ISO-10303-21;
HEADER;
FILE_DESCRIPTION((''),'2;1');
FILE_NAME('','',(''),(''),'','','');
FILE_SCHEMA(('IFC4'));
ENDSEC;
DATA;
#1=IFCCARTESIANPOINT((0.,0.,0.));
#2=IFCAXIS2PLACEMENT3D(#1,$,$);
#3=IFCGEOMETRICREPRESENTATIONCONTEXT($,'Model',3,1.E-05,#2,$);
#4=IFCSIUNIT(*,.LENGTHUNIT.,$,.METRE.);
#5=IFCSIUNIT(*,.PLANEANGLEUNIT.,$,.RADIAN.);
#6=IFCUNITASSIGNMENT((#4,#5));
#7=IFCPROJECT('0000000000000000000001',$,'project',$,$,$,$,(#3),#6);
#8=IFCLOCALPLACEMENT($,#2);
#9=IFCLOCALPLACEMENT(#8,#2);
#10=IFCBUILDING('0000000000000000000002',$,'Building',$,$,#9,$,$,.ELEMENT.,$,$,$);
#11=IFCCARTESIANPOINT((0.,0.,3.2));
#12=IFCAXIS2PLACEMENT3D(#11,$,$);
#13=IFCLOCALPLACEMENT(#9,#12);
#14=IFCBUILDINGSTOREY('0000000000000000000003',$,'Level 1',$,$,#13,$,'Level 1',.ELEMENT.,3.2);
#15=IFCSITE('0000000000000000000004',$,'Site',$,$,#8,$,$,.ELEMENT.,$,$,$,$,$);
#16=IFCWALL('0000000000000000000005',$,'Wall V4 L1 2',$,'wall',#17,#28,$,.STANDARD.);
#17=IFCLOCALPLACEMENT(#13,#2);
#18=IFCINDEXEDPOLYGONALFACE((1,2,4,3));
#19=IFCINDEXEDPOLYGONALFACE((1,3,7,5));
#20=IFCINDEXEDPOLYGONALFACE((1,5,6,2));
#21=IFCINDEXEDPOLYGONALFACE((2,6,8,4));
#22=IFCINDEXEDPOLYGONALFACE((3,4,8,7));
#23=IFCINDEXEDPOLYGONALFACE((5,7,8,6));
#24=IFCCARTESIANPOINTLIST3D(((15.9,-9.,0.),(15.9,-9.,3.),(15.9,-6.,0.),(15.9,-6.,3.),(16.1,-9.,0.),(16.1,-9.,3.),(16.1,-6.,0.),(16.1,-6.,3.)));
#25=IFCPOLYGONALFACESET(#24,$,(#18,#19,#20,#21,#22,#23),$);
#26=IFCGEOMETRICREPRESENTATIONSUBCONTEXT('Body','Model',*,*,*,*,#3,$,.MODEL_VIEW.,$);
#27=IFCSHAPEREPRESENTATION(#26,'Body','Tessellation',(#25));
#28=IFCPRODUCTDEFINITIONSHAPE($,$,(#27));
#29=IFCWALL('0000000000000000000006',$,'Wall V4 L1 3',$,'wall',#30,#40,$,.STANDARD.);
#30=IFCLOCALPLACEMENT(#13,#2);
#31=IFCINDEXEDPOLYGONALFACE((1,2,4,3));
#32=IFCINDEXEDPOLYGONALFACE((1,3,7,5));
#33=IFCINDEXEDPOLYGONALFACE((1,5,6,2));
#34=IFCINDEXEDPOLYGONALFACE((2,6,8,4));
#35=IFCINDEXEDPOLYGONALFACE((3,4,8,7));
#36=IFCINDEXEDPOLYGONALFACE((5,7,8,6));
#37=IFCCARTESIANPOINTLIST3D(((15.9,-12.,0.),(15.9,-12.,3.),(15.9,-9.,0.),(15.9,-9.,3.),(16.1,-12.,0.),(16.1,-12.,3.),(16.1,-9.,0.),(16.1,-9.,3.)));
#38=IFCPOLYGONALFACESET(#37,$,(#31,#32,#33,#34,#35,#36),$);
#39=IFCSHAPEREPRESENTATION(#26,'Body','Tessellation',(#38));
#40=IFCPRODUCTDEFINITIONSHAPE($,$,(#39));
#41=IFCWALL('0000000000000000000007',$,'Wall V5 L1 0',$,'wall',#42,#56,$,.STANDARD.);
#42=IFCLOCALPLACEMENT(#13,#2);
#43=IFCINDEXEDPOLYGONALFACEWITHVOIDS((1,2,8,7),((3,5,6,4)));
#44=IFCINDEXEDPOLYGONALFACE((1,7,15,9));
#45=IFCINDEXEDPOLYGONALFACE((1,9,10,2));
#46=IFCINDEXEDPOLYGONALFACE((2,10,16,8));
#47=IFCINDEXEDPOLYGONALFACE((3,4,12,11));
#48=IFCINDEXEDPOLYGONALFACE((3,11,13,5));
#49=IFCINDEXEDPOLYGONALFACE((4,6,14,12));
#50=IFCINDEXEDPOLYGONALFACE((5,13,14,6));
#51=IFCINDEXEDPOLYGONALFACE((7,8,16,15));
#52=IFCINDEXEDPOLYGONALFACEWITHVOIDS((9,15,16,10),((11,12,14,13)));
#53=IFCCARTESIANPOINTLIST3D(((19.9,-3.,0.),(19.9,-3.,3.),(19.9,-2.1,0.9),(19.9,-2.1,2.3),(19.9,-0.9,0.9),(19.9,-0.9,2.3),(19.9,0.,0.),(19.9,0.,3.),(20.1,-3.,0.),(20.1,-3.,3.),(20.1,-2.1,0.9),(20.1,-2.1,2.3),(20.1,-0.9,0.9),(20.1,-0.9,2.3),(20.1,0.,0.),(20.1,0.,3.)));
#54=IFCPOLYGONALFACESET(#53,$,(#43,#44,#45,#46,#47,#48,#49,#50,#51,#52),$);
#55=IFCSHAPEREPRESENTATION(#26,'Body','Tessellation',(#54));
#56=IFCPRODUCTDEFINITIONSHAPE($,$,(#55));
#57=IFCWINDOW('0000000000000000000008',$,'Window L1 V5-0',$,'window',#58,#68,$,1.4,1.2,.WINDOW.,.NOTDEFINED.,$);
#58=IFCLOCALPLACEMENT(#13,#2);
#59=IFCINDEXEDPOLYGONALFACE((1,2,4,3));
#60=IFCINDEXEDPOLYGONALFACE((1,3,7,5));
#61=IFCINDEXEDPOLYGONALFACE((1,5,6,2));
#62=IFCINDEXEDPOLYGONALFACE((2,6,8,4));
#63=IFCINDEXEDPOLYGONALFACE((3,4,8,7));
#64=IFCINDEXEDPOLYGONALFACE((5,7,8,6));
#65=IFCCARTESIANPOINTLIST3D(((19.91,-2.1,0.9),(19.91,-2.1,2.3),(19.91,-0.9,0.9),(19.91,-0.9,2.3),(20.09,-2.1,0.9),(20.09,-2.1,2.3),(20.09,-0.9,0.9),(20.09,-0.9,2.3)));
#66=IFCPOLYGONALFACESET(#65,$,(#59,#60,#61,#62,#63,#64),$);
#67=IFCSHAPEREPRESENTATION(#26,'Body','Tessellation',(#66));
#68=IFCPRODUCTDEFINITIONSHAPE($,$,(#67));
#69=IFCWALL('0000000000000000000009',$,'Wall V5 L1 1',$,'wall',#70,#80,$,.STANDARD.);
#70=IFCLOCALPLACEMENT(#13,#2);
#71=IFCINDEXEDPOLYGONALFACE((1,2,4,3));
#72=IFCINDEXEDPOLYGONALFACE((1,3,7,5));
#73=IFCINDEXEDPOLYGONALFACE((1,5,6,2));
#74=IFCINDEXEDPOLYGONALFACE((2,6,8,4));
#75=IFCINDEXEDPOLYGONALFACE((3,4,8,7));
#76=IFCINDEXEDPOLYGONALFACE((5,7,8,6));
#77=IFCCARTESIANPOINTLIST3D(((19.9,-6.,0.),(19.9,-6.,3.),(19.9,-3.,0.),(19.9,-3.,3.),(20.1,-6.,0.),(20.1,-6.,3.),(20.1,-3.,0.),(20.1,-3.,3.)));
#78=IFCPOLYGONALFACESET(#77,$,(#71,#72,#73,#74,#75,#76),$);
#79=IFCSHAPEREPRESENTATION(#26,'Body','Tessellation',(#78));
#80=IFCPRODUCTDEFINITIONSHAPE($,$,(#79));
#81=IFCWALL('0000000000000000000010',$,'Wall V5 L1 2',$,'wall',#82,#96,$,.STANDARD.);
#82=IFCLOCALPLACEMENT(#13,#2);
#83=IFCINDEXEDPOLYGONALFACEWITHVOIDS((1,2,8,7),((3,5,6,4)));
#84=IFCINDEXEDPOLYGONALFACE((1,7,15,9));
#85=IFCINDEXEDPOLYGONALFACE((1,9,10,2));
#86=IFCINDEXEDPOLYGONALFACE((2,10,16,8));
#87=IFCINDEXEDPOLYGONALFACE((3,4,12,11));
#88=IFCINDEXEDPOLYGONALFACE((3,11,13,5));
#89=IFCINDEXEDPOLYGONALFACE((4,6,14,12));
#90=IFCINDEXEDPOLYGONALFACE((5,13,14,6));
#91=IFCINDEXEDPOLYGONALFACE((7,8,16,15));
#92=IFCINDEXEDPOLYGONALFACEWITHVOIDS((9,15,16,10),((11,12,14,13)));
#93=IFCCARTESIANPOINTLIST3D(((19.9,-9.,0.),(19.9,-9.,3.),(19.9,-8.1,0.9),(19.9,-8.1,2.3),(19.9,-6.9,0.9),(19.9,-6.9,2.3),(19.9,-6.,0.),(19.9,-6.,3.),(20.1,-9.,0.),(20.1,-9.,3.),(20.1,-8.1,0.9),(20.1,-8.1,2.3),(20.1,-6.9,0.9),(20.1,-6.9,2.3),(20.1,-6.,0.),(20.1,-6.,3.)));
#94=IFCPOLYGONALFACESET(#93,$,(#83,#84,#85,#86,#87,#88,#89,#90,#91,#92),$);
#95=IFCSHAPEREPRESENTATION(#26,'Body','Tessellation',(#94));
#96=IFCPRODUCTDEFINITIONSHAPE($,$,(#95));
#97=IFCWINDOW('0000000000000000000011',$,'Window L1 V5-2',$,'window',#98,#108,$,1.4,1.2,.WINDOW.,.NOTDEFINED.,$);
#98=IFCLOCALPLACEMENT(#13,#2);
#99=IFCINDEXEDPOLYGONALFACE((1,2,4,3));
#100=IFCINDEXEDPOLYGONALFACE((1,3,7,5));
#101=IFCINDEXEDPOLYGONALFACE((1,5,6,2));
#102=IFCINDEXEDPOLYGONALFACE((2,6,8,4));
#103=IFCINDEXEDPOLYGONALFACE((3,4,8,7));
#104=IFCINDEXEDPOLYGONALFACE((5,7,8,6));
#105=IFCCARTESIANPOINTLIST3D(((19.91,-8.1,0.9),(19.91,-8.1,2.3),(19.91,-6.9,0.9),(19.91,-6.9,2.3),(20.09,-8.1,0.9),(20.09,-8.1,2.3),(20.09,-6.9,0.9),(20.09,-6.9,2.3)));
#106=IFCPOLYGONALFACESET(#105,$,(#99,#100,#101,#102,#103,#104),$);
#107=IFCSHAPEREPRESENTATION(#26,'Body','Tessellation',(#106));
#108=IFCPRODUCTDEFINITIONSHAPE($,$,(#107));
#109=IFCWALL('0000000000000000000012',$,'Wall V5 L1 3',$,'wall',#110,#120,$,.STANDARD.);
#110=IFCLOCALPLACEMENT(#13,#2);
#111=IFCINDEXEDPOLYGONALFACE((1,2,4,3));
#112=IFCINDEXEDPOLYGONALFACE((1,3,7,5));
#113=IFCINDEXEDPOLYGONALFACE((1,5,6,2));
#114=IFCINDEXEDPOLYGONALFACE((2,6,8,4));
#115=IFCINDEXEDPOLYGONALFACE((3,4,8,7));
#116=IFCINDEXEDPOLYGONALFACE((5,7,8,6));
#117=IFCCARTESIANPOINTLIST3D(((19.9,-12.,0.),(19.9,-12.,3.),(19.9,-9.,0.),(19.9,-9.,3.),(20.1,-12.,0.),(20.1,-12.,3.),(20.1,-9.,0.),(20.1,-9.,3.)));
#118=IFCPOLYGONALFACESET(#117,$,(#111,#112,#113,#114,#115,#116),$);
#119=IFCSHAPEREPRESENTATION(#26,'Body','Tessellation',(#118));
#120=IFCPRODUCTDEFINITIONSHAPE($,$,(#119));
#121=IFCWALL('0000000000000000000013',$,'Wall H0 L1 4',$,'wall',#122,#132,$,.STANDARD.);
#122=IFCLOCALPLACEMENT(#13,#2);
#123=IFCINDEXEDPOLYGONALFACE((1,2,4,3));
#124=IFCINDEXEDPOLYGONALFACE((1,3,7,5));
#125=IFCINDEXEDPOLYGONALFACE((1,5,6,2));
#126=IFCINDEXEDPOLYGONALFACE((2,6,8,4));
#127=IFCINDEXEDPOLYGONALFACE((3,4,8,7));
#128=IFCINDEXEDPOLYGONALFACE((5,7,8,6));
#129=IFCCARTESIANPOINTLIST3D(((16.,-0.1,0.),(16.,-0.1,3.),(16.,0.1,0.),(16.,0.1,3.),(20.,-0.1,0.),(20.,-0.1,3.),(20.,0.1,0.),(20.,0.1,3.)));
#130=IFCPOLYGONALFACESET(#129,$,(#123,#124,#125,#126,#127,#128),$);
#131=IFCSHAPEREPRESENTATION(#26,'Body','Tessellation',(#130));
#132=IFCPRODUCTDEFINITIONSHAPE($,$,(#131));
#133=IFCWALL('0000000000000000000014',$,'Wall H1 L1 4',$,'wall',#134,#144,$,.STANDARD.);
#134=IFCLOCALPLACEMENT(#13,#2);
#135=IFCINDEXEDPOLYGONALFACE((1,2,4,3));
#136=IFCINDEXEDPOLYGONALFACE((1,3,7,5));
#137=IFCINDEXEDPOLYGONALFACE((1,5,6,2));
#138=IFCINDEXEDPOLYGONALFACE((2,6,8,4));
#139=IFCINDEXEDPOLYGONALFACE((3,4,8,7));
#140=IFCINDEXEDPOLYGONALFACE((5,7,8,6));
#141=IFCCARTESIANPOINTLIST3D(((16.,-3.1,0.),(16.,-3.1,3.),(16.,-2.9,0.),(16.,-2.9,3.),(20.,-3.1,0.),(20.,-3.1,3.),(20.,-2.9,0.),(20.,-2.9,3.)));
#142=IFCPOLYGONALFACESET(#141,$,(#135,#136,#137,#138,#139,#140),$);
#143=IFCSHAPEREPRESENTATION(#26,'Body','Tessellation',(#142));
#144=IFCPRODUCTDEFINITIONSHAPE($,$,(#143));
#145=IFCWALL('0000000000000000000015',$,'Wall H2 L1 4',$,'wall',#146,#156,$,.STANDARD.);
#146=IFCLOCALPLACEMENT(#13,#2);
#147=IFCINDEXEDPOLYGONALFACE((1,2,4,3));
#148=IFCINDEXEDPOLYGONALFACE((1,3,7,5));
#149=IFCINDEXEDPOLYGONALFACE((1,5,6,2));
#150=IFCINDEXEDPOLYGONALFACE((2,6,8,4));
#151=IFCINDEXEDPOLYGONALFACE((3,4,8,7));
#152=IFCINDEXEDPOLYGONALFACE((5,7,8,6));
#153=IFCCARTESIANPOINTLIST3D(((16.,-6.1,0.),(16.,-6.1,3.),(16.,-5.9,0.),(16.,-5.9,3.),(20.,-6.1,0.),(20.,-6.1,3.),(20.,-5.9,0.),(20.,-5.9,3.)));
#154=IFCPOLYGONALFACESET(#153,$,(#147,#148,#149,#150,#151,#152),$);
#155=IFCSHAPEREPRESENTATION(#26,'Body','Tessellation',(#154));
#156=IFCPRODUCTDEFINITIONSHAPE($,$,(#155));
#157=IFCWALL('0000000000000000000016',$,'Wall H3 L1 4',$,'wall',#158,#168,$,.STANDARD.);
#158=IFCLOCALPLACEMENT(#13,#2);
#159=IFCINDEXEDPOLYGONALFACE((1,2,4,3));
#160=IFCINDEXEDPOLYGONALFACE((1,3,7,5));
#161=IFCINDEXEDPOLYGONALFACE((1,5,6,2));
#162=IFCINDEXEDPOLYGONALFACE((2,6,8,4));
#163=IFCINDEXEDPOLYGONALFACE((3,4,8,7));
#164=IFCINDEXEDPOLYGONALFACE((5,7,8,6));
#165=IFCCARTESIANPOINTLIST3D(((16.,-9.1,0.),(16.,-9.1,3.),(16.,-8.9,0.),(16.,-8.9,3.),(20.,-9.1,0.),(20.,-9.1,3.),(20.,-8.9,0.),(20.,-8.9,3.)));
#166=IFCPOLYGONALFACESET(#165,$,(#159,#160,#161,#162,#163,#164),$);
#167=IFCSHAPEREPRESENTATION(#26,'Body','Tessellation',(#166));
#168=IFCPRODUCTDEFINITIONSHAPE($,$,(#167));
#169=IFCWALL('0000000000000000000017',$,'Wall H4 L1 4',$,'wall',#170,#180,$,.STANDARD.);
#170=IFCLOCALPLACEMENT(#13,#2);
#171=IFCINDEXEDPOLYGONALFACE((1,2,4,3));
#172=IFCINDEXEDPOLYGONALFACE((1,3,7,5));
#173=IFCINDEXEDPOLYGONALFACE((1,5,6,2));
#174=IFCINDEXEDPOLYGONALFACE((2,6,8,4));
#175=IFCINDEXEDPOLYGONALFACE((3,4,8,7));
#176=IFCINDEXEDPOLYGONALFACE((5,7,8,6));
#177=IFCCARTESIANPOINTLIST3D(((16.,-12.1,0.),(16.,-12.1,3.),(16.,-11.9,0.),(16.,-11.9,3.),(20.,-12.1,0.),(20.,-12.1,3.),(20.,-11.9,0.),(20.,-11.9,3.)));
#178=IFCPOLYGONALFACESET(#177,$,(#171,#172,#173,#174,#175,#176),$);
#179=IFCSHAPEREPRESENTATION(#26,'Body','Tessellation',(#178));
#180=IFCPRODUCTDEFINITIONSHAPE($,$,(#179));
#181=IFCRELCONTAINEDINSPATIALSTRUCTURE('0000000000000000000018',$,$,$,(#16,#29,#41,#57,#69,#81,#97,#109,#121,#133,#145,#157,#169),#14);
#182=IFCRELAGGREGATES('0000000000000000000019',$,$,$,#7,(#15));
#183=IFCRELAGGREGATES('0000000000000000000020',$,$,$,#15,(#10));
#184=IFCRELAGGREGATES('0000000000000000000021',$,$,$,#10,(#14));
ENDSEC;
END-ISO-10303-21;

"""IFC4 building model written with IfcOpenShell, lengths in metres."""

from ifc_helpers import new_model, si_unit, frame, frame_2d, origin, origin_2d, place, context, subcontext, project, spatial, rectangle, extrude, element, fill, save


model = new_model("IFC4")

# Units and contexts
model_context = context("Model", 3, precision=1e-05, world=origin())
body_context = subcontext(model_context, "Body", "Model", "MODEL_VIEW")
ifc_project = project(units=[si_unit("LENGTHUNIT", "METRE"), si_unit("PLANEANGLEUNIT", "RADIAN")], contexts=[model_context])

# Site, building, storey
site_placement = place(None, origin())
site = spatial("IfcSite", under=ifc_project, at=site_placement, Name="Site", CompositionType="ELEMENT")
building_placement = place(site_placement, origin())
building = spatial("IfcBuilding", under=site, at=building_placement, Name="Building", CompositionType="ELEMENT")
storey_placement = place(building_placement, frame((0.0, 0.0, 3.2)))
storey = spatial("IfcBuildingStorey", under=building, at=storey_placement, Name="Level 1", LongName="Level 1", CompositionType="ELEMENT", Elevation=3.2)

# Walls
for number, where, z_axis, x_axis, name in (
    (1, (16.0, -6.0, 0.0), (0.0, 0.0, 1.0), (0.0, -1.0, 0.0), "Wall V4 L1 2"),
    (2, (16.0, -9.0, 0.0), (0.0, 0.0, 1.0), (0.0, -1.0, 0.0), "Wall V4 L1 3"),
):
    element("IfcWall", number, at=place(storey_placement, frame(where, z_axis=z_axis, x_axis=x_axis)), inside=storey, Name=name, ObjectType="wall", PredefinedType="STANDARD", context=body_context, shape_type="SweptSolid", body=[
        extrude(rectangle(XDim=3.0, YDim=0.2, at=frame_2d((1.5, 0.0))), origin(), (0.0, 0.0, 1.0), 3.0),
    ])

# Wall, opening, window
wall_1_placement = place(storey_placement, frame((20.0, 0.0, 0.0), z_axis=(0.0, 0.0, 1.0), x_axis=(0.0, -1.0, 0.0)))
wall_1 = element("IfcWall", 3, at=wall_1_placement, inside=storey, Name="Wall V5 L1 0", ObjectType="wall", PredefinedType="STANDARD", context=body_context, shape_type="SweptSolid", body=[
    extrude(rectangle(XDim=3.0, YDim=0.2, at=frame_2d((1.5, 0.0))), origin(), (0.0, 0.0, 1.0), 3.0),
])
opening_1_placement = place(storey_placement, frame((20.0, -1.5, 0.9), z_axis=(0.0, 0.0, 1.0), x_axis=(0.0, -1.0, 0.0)))
opening_1 = element("IfcOpeningElement", 4, at=opening_1_placement, cuts=wall_1, ObjectType="Opening", PredefinedType="OPENING", context=body_context, shape_type="SweptSolid", body=[
    extrude(rectangle(XDim=1.2, YDim=0.22, at=origin_2d()), origin(), (0.0, 0.0, 1.0), 1.4),
])
window_1_placement = place(storey_placement, frame((20.0, -1.5, 0.9), z_axis=(0.0, 0.0, 1.0), x_axis=(0.0, -1.0, 0.0)))
window_1 = element("IfcWindow", 5, at=window_1_placement, inside=storey, Name="Window L1 V5-0", ObjectType="window", OverallHeight=1.4, OverallWidth=1.2, PartitioningType="NOTDEFINED", PredefinedType="WINDOW", context=body_context, shape_type="SweptSolid", body=[
    extrude(rectangle(XDim=1.2, YDim=0.18, at=origin_2d()), origin(), (0.0, 0.0, 1.0), 1.4),
])
fill(opening_1, window_1)

# Wall
wall_2_placement = place(storey_placement, frame((20.0, -3.0, 0.0), z_axis=(0.0, 0.0, 1.0), x_axis=(0.0, -1.0, 0.0)))
element("IfcWall", 6, at=wall_2_placement, inside=storey, Name="Wall V5 L1 1", ObjectType="wall", PredefinedType="STANDARD", context=body_context, shape_type="SweptSolid", body=[
    extrude(rectangle(XDim=3.0, YDim=0.2, at=frame_2d((1.5, 0.0))), origin(), (0.0, 0.0, 1.0), 3.0),
])

# Wall, opening, window
wall_3_placement = place(storey_placement, frame((20.0, -6.0, 0.0), z_axis=(0.0, 0.0, 1.0), x_axis=(0.0, -1.0, 0.0)))
wall_3 = element("IfcWall", 7, at=wall_3_placement, inside=storey, Name="Wall V5 L1 2", ObjectType="wall", PredefinedType="STANDARD", context=body_context, shape_type="SweptSolid", body=[
    extrude(rectangle(XDim=3.0, YDim=0.2, at=frame_2d((1.5, 0.0))), origin(), (0.0, 0.0, 1.0), 3.0),
])
opening_2_placement = place(storey_placement, frame((20.0, -7.5, 0.9), z_axis=(0.0, 0.0, 1.0), x_axis=(0.0, -1.0, 0.0)))
opening_2 = element("IfcOpeningElement", 8, at=opening_2_placement, cuts=wall_3, ObjectType="Opening", PredefinedType="OPENING", context=body_context, shape_type="SweptSolid", body=[
    extrude(rectangle(XDim=1.2, YDim=0.22, at=origin_2d()), origin(), (0.0, 0.0, 1.0), 1.4),
])
window_2_placement = place(storey_placement, frame((20.0, -7.5, 0.9), z_axis=(0.0, 0.0, 1.0), x_axis=(0.0, -1.0, 0.0)))
window_2 = element("IfcWindow", 9, at=window_2_placement, inside=storey, Name="Window L1 V5-2", ObjectType="window", OverallHeight=1.4, OverallWidth=1.2, PartitioningType="NOTDEFINED", PredefinedType="WINDOW", context=body_context, shape_type="SweptSolid", body=[
    extrude(rectangle(XDim=1.2, YDim=0.18, at=origin_2d()), origin(), (0.0, 0.0, 1.0), 1.4),
])
fill(opening_2, window_2)

# Walls
wall_4_placement = place(storey_placement, frame((20.0, -9.0, 0.0), z_axis=(0.0, 0.0, 1.0), x_axis=(0.0, -1.0, 0.0)))
element("IfcWall", 10, at=wall_4_placement, inside=storey, Name="Wall V5 L1 3", ObjectType="wall", PredefinedType="STANDARD", context=body_context, shape_type="SweptSolid", body=[
    extrude(rectangle(XDim=3.0, YDim=0.2, at=frame_2d((1.5, 0.0))), origin(), (0.0, 0.0, 1.0), 3.0),
])
for number, where, z_axis, x_axis, name in (
    (11, (16.0, 0.0, 0.0), (0.0, 0.0, 1.0), (1.0, 0.0, 0.0), "Wall H0 L1 4"),
    (12, (16.0, -3.0, 0.0), (0.0, 0.0, 1.0), (1.0, 0.0, 0.0), "Wall H1 L1 4"),
    (13, (16.0, -6.0, 0.0), (0.0, 0.0, 1.0), (1.0, 0.0, 0.0), "Wall H2 L1 4"),
    (14, (16.0, -9.0, 0.0), (0.0, 0.0, 1.0), (1.0, 0.0, 0.0), "Wall H3 L1 4"),
    (15, (16.0, -12.0, 0.0), (0.0, 0.0, 1.0), (1.0, 0.0, 0.0), "Wall H4 L1 4"),
):
    element("IfcWall", number, at=place(storey_placement, frame(where, z_axis=z_axis, x_axis=x_axis)), inside=storey, Name=name, ObjectType="wall", PredefinedType="STANDARD", context=body_context, shape_type="SweptSolid", body=[
        extrude(rectangle(XDim=4.0, YDim=0.2, at=frame_2d((2.0, 0.0))), origin(), (0.0, 0.0, 1.0), 3.0),
    ])

save(model, "model.ifc")
